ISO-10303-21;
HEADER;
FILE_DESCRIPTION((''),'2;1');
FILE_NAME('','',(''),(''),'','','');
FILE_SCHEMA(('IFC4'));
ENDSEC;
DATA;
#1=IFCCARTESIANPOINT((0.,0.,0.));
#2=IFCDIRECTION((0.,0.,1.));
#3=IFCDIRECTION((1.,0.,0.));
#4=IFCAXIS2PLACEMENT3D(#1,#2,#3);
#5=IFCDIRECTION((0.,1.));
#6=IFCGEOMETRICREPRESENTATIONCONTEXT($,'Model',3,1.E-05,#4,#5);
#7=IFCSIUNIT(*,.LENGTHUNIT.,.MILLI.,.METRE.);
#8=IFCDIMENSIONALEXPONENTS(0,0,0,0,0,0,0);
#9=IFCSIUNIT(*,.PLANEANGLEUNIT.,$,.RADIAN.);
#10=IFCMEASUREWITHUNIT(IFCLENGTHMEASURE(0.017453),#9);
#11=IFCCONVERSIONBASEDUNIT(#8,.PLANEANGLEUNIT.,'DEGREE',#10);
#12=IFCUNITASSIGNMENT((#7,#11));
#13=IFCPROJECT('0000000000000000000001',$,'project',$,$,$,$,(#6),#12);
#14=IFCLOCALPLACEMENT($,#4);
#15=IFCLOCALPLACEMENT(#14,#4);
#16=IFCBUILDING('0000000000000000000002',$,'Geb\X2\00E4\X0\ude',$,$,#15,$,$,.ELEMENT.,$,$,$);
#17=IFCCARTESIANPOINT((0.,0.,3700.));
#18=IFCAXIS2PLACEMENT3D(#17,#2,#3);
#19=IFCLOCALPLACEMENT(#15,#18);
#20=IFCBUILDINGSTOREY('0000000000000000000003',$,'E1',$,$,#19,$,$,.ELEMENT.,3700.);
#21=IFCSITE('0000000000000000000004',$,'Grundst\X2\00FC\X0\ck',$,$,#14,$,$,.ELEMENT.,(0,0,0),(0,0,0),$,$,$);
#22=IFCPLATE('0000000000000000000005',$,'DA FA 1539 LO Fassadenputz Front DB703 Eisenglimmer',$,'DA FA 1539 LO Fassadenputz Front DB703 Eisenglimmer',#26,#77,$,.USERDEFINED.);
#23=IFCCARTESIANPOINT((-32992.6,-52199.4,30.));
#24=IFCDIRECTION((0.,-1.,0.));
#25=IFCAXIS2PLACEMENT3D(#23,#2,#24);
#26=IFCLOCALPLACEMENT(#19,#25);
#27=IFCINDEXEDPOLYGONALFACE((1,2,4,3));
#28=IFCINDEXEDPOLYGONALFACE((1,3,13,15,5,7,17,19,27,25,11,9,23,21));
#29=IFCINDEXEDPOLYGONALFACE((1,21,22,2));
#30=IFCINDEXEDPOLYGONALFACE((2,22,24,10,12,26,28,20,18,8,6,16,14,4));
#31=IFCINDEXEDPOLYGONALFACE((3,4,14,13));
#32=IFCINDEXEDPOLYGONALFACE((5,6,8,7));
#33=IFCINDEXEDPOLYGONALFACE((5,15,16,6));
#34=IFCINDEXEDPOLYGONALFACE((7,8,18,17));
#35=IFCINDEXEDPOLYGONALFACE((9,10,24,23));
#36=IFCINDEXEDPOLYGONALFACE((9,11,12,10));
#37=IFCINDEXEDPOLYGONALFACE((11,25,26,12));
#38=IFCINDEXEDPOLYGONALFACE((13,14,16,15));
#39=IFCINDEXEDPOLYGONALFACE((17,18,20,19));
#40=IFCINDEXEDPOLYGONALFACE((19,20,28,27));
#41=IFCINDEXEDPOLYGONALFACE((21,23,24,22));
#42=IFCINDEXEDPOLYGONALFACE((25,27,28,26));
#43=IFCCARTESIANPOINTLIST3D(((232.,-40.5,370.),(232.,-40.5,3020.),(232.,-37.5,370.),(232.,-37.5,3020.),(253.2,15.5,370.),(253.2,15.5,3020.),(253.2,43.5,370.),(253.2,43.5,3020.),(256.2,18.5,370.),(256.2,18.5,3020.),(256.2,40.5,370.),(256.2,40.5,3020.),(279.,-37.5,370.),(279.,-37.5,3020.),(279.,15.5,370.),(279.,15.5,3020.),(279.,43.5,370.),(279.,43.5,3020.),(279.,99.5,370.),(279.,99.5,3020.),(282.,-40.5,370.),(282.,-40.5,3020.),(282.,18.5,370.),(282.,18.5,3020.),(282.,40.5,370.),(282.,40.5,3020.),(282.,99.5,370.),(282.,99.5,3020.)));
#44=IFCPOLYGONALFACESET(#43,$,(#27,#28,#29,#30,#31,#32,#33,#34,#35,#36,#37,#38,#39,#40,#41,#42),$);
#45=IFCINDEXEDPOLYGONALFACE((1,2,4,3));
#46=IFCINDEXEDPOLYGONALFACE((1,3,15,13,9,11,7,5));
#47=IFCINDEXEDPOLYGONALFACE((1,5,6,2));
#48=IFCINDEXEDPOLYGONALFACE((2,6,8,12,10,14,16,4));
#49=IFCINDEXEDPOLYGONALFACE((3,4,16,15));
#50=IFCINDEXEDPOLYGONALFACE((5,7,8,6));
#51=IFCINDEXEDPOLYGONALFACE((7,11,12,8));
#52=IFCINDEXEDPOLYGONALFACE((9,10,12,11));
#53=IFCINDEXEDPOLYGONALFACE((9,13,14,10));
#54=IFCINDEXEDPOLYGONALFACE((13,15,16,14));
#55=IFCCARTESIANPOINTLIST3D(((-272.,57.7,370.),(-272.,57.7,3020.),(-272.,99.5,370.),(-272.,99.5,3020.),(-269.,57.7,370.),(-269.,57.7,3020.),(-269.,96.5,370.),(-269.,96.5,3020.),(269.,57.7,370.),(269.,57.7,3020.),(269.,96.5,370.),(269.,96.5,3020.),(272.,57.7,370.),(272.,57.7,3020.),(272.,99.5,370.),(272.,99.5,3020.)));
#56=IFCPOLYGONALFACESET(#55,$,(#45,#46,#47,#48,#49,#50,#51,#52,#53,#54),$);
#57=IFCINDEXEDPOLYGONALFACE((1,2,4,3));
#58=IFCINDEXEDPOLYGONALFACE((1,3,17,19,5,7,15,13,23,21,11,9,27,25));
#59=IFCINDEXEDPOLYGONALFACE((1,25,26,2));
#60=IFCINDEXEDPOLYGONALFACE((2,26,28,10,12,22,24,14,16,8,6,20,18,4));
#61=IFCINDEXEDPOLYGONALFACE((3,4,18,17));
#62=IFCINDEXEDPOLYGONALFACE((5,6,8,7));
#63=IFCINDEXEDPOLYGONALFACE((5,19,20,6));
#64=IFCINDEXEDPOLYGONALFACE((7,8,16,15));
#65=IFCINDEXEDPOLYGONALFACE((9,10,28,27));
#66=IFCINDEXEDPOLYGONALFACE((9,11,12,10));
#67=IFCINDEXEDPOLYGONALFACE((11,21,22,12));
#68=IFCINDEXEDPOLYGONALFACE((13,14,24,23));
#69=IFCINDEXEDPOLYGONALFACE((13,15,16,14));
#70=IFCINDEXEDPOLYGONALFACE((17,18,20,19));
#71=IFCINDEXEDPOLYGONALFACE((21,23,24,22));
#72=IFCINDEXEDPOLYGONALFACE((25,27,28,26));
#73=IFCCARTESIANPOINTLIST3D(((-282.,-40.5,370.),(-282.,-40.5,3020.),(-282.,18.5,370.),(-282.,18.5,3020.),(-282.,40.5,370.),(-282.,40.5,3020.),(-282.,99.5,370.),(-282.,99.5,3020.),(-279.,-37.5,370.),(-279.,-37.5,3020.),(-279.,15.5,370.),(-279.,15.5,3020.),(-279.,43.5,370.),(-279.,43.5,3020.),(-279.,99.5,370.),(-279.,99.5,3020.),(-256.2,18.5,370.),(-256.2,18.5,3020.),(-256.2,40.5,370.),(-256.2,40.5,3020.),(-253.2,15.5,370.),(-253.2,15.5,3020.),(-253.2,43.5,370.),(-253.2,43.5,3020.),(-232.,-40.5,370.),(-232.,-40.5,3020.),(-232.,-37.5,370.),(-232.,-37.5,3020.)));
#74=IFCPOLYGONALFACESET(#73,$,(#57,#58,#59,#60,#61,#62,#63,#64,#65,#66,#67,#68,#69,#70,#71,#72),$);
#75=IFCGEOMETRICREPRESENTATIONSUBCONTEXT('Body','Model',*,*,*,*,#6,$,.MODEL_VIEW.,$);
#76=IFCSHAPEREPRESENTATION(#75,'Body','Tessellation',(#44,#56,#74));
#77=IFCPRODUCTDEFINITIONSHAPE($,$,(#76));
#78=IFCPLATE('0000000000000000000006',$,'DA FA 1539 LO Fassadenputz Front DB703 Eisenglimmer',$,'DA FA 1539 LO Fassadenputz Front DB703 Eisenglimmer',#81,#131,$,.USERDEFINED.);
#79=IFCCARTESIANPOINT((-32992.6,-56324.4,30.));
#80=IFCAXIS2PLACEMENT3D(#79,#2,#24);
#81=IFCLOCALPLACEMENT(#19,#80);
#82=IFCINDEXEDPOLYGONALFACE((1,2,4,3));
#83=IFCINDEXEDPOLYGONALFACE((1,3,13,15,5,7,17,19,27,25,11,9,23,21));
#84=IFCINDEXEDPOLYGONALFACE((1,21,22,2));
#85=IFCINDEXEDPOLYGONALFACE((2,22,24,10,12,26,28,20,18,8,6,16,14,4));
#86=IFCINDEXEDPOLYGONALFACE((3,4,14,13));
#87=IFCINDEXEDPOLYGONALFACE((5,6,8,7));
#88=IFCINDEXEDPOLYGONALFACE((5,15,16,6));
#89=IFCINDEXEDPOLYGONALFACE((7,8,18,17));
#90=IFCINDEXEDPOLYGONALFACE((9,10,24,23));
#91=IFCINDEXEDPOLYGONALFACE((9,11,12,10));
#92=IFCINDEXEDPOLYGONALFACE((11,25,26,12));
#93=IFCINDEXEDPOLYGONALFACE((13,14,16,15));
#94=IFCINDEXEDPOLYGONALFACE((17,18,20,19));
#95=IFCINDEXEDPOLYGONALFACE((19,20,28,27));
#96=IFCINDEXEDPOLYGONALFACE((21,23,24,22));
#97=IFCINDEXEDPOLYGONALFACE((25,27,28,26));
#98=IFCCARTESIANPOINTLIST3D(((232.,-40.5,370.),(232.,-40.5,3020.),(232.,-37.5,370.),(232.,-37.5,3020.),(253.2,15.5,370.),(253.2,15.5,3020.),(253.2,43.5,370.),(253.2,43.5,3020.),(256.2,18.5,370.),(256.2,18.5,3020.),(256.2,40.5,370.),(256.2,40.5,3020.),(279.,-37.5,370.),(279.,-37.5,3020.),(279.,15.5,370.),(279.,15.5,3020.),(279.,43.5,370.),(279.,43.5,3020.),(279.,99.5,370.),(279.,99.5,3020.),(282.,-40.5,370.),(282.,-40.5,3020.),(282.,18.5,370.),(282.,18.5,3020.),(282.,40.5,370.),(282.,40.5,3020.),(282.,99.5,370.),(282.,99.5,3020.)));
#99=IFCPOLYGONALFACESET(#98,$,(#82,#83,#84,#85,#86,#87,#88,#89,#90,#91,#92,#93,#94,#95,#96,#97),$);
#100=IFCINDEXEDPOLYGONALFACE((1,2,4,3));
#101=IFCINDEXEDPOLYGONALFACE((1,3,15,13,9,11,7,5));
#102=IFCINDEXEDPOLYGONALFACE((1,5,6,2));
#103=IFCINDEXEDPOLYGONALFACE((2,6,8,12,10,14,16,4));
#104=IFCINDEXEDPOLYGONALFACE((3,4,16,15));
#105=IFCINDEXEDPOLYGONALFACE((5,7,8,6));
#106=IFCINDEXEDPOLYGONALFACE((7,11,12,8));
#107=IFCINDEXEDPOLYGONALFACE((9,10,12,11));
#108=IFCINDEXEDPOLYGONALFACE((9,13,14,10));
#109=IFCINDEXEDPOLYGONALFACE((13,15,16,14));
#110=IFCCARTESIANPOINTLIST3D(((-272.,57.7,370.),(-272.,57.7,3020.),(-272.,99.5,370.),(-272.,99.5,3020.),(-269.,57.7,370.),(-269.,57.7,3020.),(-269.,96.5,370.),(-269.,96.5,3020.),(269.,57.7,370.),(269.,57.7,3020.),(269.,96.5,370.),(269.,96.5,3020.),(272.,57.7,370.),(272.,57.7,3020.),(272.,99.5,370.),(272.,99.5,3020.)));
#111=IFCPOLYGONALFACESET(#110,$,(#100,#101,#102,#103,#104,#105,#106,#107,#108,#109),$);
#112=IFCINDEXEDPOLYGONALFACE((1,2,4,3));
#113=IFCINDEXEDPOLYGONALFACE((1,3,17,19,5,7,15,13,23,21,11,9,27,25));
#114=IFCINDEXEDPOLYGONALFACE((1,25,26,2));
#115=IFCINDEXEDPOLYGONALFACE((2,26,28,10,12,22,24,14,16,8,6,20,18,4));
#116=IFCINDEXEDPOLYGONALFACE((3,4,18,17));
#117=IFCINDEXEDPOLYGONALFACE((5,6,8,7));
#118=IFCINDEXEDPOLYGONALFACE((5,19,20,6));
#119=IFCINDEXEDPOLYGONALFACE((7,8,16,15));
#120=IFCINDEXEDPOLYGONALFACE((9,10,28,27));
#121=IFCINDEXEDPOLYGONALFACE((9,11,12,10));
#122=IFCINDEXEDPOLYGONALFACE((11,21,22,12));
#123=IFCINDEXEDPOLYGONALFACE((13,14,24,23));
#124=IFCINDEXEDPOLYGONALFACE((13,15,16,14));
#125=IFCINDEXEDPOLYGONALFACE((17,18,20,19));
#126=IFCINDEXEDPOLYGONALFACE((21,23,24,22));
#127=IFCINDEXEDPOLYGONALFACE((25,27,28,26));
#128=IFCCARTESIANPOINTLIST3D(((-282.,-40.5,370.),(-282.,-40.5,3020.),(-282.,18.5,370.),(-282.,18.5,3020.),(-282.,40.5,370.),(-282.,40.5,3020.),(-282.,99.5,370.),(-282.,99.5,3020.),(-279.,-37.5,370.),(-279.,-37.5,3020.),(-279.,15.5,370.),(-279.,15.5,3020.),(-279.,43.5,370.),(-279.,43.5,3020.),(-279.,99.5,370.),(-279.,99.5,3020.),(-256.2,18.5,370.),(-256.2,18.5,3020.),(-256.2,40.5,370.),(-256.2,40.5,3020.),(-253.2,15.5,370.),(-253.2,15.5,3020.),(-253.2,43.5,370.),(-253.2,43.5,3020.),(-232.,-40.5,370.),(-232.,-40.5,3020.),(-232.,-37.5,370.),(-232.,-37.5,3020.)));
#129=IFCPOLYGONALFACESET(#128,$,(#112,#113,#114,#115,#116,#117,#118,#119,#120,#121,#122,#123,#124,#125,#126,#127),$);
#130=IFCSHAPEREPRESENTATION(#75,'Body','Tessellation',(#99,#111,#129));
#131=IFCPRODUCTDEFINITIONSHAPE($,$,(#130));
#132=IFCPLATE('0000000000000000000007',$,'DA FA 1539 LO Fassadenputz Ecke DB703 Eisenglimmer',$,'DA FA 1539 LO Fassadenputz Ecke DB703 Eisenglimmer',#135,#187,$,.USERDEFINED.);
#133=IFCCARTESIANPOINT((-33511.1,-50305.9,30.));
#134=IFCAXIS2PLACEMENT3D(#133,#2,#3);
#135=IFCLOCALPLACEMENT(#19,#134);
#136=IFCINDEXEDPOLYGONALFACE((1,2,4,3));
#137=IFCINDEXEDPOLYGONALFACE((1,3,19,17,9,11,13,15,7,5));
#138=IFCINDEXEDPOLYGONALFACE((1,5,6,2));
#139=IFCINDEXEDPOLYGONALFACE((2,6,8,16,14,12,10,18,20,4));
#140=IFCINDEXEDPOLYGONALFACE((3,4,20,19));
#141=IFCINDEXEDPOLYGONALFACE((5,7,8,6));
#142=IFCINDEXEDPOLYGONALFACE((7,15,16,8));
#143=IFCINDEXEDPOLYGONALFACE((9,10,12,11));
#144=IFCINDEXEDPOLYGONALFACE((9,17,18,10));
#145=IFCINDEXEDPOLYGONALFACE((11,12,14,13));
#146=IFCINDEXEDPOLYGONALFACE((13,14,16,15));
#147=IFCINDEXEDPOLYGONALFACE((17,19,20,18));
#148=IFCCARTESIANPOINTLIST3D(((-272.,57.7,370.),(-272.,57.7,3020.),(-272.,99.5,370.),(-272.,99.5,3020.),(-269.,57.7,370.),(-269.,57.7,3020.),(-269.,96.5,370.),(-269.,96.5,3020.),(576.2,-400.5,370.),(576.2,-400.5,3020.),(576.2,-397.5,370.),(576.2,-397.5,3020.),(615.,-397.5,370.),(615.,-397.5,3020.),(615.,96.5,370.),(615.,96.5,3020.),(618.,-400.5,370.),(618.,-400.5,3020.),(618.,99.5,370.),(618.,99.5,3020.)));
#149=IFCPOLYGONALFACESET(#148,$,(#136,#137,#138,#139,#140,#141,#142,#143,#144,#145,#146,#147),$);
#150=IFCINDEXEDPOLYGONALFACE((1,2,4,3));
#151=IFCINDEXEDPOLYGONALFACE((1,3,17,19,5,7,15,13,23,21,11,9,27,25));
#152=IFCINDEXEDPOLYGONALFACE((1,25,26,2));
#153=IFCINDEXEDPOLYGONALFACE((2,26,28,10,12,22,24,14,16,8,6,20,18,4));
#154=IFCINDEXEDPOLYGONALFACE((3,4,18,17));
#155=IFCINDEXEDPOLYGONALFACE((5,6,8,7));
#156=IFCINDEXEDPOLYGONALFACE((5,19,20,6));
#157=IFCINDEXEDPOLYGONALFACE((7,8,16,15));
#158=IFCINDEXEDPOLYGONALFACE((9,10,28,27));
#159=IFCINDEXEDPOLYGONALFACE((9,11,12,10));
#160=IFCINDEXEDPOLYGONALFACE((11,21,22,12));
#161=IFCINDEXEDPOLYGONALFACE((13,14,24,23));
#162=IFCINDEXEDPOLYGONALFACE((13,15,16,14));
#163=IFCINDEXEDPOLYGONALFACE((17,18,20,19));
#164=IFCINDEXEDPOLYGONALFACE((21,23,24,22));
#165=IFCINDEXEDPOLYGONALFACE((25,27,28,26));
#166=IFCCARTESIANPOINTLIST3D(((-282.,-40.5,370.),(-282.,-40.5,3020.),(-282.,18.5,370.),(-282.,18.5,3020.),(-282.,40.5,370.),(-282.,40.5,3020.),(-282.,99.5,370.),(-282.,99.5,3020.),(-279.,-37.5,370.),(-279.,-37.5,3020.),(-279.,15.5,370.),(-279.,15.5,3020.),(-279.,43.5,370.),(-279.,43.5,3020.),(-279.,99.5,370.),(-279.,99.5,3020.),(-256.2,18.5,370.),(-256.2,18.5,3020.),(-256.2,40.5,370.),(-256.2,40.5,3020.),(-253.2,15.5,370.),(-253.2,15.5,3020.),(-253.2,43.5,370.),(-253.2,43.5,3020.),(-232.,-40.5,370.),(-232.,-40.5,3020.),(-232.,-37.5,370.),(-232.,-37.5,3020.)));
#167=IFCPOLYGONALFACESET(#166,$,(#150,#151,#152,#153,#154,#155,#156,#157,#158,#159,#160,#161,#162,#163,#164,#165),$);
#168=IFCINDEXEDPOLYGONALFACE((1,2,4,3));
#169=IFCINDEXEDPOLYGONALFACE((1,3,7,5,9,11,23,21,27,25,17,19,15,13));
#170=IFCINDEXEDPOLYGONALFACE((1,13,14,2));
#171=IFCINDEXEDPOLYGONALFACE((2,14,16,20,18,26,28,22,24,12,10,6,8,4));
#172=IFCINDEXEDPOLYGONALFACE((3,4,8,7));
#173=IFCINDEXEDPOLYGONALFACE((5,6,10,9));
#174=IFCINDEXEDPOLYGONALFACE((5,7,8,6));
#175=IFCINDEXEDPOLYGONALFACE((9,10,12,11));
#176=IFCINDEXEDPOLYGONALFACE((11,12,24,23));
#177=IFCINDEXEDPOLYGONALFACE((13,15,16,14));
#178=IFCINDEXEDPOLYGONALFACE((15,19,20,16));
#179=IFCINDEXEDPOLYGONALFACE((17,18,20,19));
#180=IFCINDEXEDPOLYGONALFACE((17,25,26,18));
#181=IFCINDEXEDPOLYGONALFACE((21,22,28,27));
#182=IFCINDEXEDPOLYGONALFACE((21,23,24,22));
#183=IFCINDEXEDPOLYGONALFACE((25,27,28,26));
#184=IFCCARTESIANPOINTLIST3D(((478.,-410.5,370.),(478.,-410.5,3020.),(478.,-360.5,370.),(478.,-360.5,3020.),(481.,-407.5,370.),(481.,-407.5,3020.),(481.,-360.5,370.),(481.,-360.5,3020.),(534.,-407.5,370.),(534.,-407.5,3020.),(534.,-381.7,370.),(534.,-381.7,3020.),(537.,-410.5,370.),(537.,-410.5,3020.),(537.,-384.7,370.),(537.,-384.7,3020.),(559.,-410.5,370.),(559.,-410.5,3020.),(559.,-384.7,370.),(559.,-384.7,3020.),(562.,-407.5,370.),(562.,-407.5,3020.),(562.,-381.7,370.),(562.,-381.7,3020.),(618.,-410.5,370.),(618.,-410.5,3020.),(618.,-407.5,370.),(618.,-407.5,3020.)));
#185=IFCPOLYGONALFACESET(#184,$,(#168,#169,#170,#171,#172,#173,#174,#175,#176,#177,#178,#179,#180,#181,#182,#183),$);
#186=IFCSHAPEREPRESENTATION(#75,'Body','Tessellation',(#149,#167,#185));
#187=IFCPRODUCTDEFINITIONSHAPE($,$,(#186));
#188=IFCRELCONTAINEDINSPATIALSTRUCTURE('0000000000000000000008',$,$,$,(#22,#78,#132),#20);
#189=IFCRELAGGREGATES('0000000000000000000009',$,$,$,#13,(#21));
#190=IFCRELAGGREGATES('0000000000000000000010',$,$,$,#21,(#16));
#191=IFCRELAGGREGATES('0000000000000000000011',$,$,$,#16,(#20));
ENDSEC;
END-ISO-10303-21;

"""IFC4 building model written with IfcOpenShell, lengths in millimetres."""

from ifc_helpers import new_model, entity, si_unit, converted_unit, direction, frame, origin_with_axes, place, context, subcontext, project, spatial, line, indexed_curve, outline, extrude, source, transform, mapped, element, save


model = new_model("IFC4")

# Units and contexts
model_context = context("Model", 3, precision=1e-05, world=origin_with_axes(), true_north=direction((0.0, 1.0)))
body_context = subcontext(model_context, "Body", "Model", "MODEL_VIEW")
ifc_project = project(units=[si_unit("LENGTHUNIT", "METRE", prefix="MILLI"), converted_unit("PLANEANGLEUNIT", "DEGREE", entity("IfcLengthMeasure", 0.017453), si_unit("PLANEANGLEUNIT", "RADIAN"), dimensions=[0, 0, 0, 0, 0, 0, 0])], contexts=[model_context])

# Site, building, storey
site_placement = place(None, origin_with_axes())
site = spatial("IfcSite", under=ifc_project, at=site_placement, Name="Grundstück", CompositionType="ELEMENT", RefLatitude=(0, 0, 0), RefLongitude=(0, 0, 0))
building_placement = place(site_placement, origin_with_axes())
building = spatial("IfcBuilding", under=site, at=building_placement, Name="Gebäude", CompositionType="ELEMENT")
storey_placement = place(building_placement, frame((0.0, 0.0, 3700.0), z_axis=(0.0, 0.0, 1.0), x_axis=(1.0, 0.0, 0.0)))
storey = spatial("IfcBuildingStorey", under=building, at=storey_placement, Name="E1", CompositionType="ELEMENT", Elevation=3700.0)

# Plates
shared_shape_1 = source(origin_with_axes(), body_context, "Body", "SweptSolid", [
    extrude(outline(indexed_curve([(282.0, 99.5), (282.0, 40.5), (256.2, 40.5), (256.2, 18.5), (282.0, 18.5), (282.0, -40.5), (232.0, -40.5), (232.0, -37.5), (279.0, -37.5), (279.0, 15.5), (253.2, 15.5), (253.2, 43.5), (279.0, 43.5), (279.0, 99.5)], segments=[line(1, 2), line(2, 3), line(3, 4), line(4, 5), line(5, 6), line(6, 7), line(7, 8), line(8, 9), line(9, 10), line(10, 11), line(11, 12), line(12, 13), line(13, 14), line(14, 1)])), frame((0.0, 0.0, 370.0), z_axis=(0.0, 0.0, 1.0), x_axis=(1.0, 0.0, 0.0)), (0.0, 0.0, 1.0), 2650.0),
    extrude(outline(indexed_curve([(272.0, 99.5), (272.0, 57.7), (269.0, 57.7), (269.0, 96.5), (-269.0, 96.5), (-269.0, 57.7), (-272.0, 57.7), (-272.0, 99.5)], segments=[line(1, 2), line(2, 3), line(3, 4), line(4, 5), line(5, 6), line(6, 7), line(7, 8), line(8, 1)])), frame((0.0, 0.0, 370.0), z_axis=(0.0, 0.0, 1.0), x_axis=(1.0, 0.0, 0.0)), (0.0, 0.0, 1.0), 2650.0),
    extrude(outline(indexed_curve([(-282.0, 99.5), (-282.0, 40.5), (-256.2, 40.5), (-256.2, 18.5), (-282.0, 18.5), (-282.0, -40.5), (-232.0, -40.5), (-232.0, -37.5), (-279.0, -37.5), (-279.0, 15.5), (-253.2, 15.5), (-253.2, 43.5), (-279.0, 43.5), (-279.0, 99.5)], segments=[line(1, 2), line(2, 3), line(3, 4), line(4, 5), line(5, 6), line(6, 7), line(7, 8), line(8, 9), line(9, 10), line(10, 11), line(11, 12), line(12, 13), line(13, 14), line(14, 1)])), frame((0.0, 0.0, 370.0), z_axis=(0.0, 0.0, 1.0), x_axis=(1.0, 0.0, 0.0)), (0.0, 0.0, 1.0), 2650.0),
])
for number, where, z_axis, x_axis, name in (
    (1, (-32992.6, -52199.4, 30.0), (0.0, 0.0, 1.0), (0.0, -1.0, 0.0), "DA FA 1539 LO Fassadenputz Front DB703 Eisenglimmer"),
    (2, (-32992.6, -56324.4, 30.0), (0.0, 0.0, 1.0), (0.0, -1.0, 0.0), "DA FA 1539 LO Fassadenputz Front DB703 Eisenglimmer"),
):
    element("IfcPlate", number, at=place(storey_placement, frame(where, z_axis=z_axis, x_axis=x_axis)), inside=storey, Name=name, ObjectType="DA FA 1539 LO Fassadenputz Front DB703 Eisenglimmer", PredefinedType="USERDEFINED", context=body_context, shape_type="MappedRepresentation", body=[
        mapped(shared_shape_1, transform((0.0, 0.0, 0.0), x_axis=(1.0, 0.0, 0.0), y_axis=(0.0, 1.0, 0.0), z_axis=(0.0, 0.0, 1.0), scale=1.0)),
    ])
shared_shape_2 = source(origin_with_axes(), body_context, "Body", "SweptSolid", [
    extrude(outline(indexed_curve([(618.0, -400.5), (576.2, -400.5), (576.2, -397.5), (615.0, -397.5), (615.0, 96.5), (-269.0, 96.5), (-269.0, 57.7), (-272.0, 57.7), (-272.0, 99.5), (618.0, 99.5)], segments=[line(1, 2), line(2, 3), line(3, 4), line(4, 5), line(5, 6), line(6, 7), line(7, 8), line(8, 9), line(9, 10), line(10, 1)])), frame((0.0, 0.0, 370.0), z_axis=(0.0, 0.0, 1.0), x_axis=(1.0, 0.0, 0.0)), (0.0, 0.0, 1.0), 2650.0),
    extrude(outline(indexed_curve([(-282.0, 99.5), (-282.0, 40.5), (-256.2, 40.5), (-256.2, 18.5), (-282.0, 18.5), (-282.0, -40.5), (-232.0, -40.5), (-232.0, -37.5), (-279.0, -37.5), (-279.0, 15.5), (-253.2, 15.5), (-253.2, 43.5), (-279.0, 43.5), (-279.0, 99.5)], segments=[line(1, 2), line(2, 3), line(3, 4), line(4, 5), line(5, 6), line(6, 7), line(7, 8), line(8, 9), line(9, 10), line(10, 11), line(11, 12), line(12, 13), line(13, 14), line(14, 1)])), frame((0.0, 0.0, 370.0), z_axis=(0.0, 0.0, 1.0), x_axis=(1.0, 0.0, 0.0)), (0.0, 0.0, 1.0), 2650.0),
    extrude(outline(indexed_curve([(618.0, -410.5), (559.0, -410.5), (559.0, -384.7), (537.0, -384.7), (537.0, -410.5), (478.0, -410.5), (478.0, -360.5), (481.0, -360.5), (481.0, -407.5), (534.0, -407.5), (534.0, -381.7), (562.0, -381.7), (562.0, -407.5), (618.0, -407.5)], segments=[line(1, 2), line(2, 3), line(3, 4), line(4, 5), line(5, 6), line(6, 7), line(7, 8), line(8, 9), line(9, 10), line(10, 11), line(11, 12), line(12, 13), line(13, 14), line(14, 1)])), frame((0.0, 0.0, 370.0), z_axis=(0.0, 0.0, 1.0), x_axis=(1.0, 0.0, 0.0)), (0.0, 0.0, 1.0), 2650.0),
])
plate_1_placement = place(storey_placement, frame((-33511.1, -50305.9, 30.0), z_axis=(0.0, 0.0, 1.0), x_axis=(1.0, 0.0, 0.0)))
element("IfcPlate", 3, at=plate_1_placement, inside=storey, Name="DA FA 1539 LO Fassadenputz Ecke DB703 Eisenglimmer", ObjectType="DA FA 1539 LO Fassadenputz Ecke DB703 Eisenglimmer", PredefinedType="USERDEFINED", context=body_context, shape_type="MappedRepresentation", body=[
    mapped(shared_shape_2, transform((0.0, 0.0, 0.0), x_axis=(1.0, 0.0, 0.0), y_axis=(0.0, 1.0, 0.0), z_axis=(0.0, 0.0, 1.0), scale=1.0)),
])

save(model, "model.ifc")
